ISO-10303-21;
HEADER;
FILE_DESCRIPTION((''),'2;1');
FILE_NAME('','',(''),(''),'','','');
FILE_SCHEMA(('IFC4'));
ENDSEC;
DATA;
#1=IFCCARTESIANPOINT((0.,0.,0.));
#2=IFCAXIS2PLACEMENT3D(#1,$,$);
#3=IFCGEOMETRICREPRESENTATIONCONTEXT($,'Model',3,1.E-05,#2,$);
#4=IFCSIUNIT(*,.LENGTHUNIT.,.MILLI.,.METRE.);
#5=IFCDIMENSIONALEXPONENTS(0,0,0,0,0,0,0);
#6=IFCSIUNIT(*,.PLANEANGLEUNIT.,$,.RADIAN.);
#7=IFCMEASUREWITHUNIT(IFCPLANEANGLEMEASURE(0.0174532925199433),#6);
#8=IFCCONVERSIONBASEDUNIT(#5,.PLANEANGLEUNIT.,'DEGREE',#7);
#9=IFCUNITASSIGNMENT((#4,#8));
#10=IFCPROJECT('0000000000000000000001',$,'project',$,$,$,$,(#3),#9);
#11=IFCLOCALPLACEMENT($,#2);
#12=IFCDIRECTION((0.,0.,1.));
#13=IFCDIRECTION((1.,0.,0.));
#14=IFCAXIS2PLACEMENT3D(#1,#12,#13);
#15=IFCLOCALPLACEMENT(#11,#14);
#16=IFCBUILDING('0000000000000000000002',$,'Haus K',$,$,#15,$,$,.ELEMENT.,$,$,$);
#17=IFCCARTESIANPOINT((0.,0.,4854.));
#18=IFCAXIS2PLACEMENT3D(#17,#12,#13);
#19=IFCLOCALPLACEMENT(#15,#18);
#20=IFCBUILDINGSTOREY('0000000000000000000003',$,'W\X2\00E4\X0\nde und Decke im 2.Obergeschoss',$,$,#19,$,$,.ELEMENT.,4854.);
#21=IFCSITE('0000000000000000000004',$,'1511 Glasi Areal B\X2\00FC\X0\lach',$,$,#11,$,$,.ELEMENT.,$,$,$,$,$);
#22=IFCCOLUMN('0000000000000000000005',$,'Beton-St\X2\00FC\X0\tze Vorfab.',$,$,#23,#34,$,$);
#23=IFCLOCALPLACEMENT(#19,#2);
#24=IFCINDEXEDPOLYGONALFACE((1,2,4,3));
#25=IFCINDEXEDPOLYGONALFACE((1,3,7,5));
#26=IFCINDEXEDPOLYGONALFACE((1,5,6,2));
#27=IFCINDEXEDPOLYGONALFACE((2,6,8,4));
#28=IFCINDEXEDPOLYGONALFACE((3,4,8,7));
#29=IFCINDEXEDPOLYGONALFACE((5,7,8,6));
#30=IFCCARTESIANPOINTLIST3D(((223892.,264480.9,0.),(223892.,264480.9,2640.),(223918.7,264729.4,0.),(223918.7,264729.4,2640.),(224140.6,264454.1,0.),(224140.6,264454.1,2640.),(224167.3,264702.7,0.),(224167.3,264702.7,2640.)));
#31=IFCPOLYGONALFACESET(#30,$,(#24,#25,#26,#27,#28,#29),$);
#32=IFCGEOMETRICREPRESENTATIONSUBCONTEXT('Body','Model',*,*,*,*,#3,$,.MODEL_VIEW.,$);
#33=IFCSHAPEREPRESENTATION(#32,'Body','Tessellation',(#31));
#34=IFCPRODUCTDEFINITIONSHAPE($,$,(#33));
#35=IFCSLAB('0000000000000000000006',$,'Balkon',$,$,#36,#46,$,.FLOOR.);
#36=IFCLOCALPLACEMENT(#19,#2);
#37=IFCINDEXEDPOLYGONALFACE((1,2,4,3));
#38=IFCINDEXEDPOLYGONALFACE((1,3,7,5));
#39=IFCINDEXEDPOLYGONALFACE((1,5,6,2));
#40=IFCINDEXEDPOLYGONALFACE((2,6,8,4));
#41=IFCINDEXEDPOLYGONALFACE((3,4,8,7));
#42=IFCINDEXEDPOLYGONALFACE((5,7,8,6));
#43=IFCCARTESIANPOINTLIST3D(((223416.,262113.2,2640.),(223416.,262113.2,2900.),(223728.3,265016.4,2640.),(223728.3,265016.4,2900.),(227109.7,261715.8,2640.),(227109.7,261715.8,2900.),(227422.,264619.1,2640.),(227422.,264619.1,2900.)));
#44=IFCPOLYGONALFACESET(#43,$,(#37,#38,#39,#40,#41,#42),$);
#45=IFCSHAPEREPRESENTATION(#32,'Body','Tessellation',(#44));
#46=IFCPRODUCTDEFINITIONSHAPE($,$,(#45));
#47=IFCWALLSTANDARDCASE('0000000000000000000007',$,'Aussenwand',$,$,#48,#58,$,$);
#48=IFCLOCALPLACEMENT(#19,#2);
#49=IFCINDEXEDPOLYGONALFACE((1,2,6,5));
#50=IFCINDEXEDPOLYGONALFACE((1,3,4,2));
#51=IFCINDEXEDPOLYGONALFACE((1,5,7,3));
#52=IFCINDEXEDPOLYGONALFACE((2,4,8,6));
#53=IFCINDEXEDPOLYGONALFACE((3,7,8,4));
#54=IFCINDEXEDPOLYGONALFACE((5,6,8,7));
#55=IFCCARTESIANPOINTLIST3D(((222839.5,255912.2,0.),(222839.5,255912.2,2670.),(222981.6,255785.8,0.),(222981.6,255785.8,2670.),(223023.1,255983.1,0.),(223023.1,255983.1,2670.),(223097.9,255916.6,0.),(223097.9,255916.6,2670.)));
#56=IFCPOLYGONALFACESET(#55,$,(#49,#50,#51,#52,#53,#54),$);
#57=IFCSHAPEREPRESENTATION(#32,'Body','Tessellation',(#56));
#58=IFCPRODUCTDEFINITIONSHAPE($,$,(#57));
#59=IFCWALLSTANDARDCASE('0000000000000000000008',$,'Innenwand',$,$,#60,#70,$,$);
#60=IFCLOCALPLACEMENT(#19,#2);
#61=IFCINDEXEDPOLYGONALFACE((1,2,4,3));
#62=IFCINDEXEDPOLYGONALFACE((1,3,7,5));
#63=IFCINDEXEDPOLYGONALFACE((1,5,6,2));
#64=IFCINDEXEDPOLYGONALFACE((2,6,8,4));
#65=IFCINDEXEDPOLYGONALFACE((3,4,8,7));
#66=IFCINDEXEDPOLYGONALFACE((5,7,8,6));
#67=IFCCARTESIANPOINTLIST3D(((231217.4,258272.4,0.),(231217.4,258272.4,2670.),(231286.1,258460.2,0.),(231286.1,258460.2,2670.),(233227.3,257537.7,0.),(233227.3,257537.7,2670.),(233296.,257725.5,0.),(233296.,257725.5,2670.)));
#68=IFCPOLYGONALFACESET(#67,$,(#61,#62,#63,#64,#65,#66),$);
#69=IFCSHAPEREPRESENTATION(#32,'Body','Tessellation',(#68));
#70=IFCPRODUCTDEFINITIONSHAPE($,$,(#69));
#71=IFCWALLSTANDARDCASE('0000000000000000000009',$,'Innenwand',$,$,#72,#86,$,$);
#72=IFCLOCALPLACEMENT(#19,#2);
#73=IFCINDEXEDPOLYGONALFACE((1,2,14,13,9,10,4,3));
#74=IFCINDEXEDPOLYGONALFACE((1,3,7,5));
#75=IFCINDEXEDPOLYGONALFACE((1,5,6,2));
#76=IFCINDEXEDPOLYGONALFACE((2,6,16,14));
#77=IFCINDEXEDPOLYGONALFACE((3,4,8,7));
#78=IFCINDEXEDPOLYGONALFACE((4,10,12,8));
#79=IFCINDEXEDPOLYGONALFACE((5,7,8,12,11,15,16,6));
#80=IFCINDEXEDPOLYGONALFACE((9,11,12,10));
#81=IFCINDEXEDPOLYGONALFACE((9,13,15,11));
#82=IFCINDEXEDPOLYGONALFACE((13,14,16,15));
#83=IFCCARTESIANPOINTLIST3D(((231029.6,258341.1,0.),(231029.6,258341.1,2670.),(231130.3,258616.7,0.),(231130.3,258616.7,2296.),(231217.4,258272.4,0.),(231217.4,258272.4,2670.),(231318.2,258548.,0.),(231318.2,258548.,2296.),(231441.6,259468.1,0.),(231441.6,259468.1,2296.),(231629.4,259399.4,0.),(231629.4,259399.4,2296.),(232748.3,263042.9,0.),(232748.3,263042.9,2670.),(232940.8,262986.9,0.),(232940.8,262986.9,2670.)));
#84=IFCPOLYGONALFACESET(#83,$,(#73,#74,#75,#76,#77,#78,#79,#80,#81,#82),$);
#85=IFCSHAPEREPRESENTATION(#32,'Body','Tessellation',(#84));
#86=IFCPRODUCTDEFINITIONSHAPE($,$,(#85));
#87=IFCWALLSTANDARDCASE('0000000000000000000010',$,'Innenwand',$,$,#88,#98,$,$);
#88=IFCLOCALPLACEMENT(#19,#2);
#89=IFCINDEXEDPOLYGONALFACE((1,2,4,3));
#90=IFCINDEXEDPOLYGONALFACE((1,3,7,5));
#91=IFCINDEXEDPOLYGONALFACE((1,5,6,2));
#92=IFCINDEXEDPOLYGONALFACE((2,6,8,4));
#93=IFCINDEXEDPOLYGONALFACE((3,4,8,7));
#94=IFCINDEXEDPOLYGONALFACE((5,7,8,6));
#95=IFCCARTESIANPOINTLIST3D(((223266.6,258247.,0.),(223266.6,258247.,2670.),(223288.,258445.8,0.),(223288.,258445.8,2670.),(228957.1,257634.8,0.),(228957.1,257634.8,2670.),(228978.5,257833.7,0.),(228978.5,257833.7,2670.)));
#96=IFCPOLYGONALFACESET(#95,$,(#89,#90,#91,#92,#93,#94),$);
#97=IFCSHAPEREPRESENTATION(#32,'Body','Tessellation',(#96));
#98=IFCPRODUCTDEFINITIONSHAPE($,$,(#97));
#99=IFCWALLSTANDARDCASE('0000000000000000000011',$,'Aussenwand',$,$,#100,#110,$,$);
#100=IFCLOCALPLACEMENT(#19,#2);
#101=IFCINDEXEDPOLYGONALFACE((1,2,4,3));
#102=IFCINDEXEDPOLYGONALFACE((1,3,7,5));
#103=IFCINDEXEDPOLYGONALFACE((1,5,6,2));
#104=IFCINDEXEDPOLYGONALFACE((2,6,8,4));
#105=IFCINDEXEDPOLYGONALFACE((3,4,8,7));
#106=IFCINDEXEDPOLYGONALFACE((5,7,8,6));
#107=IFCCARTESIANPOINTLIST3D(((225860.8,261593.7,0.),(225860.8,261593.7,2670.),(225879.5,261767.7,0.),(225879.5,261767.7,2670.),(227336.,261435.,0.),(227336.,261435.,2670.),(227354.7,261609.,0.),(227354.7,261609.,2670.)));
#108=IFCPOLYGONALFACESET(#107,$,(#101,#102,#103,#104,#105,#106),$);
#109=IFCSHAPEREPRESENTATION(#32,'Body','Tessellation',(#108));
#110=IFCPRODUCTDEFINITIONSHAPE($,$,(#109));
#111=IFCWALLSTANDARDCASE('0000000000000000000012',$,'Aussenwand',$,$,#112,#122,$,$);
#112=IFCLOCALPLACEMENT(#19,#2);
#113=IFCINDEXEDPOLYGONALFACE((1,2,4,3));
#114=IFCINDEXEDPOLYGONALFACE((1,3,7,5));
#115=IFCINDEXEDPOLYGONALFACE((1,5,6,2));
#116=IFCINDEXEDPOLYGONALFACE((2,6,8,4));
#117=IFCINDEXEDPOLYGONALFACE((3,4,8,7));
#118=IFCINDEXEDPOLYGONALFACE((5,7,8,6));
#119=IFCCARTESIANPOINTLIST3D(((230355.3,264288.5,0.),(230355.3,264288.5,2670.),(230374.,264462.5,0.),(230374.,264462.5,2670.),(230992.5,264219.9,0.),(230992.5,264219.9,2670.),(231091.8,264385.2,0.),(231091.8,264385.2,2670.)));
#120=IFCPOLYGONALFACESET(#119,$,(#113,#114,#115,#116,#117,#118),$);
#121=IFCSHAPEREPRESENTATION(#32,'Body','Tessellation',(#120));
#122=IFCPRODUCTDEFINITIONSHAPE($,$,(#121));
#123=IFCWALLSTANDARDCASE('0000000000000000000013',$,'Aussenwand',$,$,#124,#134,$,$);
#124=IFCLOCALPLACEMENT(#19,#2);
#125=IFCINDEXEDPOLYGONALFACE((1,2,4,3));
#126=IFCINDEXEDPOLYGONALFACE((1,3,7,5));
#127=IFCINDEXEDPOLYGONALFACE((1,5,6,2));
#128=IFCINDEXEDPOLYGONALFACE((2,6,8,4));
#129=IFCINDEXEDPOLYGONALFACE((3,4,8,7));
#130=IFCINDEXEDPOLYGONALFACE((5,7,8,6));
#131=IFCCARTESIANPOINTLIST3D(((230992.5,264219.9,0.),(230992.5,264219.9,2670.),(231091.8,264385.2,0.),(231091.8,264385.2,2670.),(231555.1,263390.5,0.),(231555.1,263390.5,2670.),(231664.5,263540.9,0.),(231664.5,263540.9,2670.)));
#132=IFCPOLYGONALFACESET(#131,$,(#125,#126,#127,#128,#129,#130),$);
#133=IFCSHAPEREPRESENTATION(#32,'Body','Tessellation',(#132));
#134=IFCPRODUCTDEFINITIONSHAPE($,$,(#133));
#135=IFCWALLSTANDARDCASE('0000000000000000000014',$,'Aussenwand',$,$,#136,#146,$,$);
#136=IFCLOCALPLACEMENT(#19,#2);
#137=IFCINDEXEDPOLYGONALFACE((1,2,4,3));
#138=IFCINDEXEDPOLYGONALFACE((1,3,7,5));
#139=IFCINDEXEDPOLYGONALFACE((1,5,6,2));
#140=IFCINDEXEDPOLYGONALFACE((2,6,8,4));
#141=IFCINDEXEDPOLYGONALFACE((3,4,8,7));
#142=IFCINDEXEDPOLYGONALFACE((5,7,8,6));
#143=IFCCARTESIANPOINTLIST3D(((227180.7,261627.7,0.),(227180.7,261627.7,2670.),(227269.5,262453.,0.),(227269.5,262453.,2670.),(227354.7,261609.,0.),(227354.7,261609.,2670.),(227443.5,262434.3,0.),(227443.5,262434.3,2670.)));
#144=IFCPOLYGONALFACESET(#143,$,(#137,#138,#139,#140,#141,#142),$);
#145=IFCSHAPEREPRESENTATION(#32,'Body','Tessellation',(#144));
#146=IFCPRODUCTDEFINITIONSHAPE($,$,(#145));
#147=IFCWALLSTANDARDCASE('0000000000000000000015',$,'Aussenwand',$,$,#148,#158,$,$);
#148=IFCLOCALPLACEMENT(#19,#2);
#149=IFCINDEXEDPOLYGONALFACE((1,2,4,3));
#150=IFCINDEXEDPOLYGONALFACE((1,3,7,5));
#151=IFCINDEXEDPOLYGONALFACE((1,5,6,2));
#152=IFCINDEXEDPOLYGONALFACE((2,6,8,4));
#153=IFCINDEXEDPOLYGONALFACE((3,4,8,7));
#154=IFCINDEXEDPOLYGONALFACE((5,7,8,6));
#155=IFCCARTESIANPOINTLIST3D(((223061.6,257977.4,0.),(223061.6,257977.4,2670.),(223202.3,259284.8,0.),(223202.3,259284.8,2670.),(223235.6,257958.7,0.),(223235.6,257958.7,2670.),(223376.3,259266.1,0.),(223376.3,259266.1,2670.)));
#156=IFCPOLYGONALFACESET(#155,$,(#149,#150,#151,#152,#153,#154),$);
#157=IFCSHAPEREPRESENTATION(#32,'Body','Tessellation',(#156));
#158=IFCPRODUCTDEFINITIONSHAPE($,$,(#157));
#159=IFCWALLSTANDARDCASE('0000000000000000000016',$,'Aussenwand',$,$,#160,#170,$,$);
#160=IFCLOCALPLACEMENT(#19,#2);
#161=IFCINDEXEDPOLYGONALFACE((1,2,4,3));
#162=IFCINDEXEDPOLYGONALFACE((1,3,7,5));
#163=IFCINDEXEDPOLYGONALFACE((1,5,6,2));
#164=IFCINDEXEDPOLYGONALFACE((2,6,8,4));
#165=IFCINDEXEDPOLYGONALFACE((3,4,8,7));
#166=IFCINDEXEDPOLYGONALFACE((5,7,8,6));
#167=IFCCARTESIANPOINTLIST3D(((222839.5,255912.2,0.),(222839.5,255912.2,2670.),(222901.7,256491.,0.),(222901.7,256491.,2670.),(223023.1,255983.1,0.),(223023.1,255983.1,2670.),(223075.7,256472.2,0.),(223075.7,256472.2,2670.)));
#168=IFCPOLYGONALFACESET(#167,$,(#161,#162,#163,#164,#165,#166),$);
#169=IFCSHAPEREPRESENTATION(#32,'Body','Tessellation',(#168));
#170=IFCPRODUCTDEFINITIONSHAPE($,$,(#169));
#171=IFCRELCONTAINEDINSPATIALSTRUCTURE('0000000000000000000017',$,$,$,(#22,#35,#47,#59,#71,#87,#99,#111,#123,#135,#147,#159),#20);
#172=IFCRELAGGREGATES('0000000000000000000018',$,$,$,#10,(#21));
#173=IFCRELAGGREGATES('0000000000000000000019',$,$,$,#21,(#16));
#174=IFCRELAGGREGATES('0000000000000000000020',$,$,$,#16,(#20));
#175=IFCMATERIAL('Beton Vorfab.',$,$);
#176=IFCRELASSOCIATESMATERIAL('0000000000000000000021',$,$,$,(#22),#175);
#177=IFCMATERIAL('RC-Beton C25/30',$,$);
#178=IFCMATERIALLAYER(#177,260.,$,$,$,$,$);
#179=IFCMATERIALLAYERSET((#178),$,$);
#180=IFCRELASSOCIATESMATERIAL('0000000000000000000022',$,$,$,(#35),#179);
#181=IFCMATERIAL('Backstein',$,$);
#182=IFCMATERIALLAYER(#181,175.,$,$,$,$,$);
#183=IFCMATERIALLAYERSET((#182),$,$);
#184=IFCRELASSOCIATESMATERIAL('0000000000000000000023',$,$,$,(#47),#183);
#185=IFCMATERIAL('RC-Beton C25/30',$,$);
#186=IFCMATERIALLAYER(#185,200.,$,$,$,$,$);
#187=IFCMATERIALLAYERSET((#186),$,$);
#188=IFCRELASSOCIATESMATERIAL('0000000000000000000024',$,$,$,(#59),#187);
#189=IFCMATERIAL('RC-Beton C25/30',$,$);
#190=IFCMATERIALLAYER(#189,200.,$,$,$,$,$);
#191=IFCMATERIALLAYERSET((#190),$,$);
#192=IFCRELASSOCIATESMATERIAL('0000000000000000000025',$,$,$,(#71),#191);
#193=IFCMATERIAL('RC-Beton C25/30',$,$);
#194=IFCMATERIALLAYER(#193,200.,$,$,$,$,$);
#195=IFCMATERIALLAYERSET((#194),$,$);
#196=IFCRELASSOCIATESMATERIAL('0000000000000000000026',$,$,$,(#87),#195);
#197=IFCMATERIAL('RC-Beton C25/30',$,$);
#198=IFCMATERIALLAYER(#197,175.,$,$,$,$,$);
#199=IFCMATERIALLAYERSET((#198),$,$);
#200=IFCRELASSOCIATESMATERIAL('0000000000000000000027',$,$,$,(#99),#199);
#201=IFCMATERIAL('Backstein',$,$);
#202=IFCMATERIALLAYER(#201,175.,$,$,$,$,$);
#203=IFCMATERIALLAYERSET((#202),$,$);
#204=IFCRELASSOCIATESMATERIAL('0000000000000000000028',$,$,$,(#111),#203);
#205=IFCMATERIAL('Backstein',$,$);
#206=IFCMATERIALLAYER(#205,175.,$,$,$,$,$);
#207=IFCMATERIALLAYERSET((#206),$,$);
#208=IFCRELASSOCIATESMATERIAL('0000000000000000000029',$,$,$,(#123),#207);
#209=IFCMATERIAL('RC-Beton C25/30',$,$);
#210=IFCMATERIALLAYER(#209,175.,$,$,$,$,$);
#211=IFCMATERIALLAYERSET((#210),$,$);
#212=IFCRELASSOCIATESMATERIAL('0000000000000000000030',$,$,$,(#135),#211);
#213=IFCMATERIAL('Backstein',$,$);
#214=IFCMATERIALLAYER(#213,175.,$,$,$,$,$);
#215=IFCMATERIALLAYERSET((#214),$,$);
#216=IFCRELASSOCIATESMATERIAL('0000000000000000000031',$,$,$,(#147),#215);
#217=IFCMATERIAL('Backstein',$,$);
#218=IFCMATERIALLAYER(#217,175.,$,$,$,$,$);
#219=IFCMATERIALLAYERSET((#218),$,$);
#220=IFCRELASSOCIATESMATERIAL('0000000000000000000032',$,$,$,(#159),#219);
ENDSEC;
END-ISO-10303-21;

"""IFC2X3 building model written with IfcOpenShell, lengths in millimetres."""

from ifc_helpers import new_model, entity, si_unit, converted_unit, frame, frame_2d, origin, origin_with_axes, place, context, subcontext, project, spatial, polyline, rectangle, outline, extrude, material, layer, layer_set, layer_usage, element, save


model = new_model("IFC2X3")

# Units and contexts
model_context = context("Model", 3, precision=1e-05, world=origin())
body_context = subcontext(model_context, "Body", "Model", "MODEL_VIEW")
ifc_project = project(units=[si_unit("LENGTHUNIT", "METRE", prefix="MILLI"), converted_unit("PLANEANGLEUNIT", "DEGREE", entity("IfcPlaneAngleMeasure", 0.0174532925199433), si_unit("PLANEANGLEUNIT", "RADIAN"), dimensions=[0, 0, 0, 0, 0, 0, 0])], contexts=[model_context])

# Site, building, storey
site_placement = place(None, origin())
site = spatial("IfcSite", under=ifc_project, at=site_placement, Name="1511 Glasi Areal Bülach", CompositionType="ELEMENT")
building_placement = place(site_placement, origin_with_axes())
building = spatial("IfcBuilding", under=site, at=building_placement, Name="Haus K", CompositionType="ELEMENT")
storey_placement = place(building_placement, frame((0.0, 0.0, 4854.0), z_axis=(0.0, 0.0, 1.0), x_axis=(1.0, 0.0, 0.0)))
storey = spatial("IfcBuildingStorey", under=building, at=storey_placement, Name="Wände und Decke im 2.Obergeschoss", CompositionType="ELEMENT", Elevation=4854.0)

# Column
ifc_material_1 = material(Name="Beton Vorfab.")
column_placement = place(storey_placement, frame((223892.0, 264480.9, 0.0), z_axis=(0.0, 0.0, 1.0), x_axis=(1.0, 0.0, 0.0)))
element("IfcColumn", 1, at=column_placement, inside=storey, material=ifc_material_1, Name="Beton-Stütze Vorfab.", context=body_context, shape_type="SweptSolid", body=[
    extrude(rectangle(XDim=250.0, YDim=250.0, at=frame_2d((137.7, 110.9), x_axis=(0.994264, -0.106958))), origin_with_axes(), (0.0, 0.0, 1.0), 2640.0),
])

# Slab
ifc_material_2 = material(Name="RC-Beton C25/30")
ifc_layer_1 = layer(ifc_material_2, 260.0)
ifc_layer_set_1 = layer_set([ifc_layer_1])
ifc_layer_usage_1 = layer_usage(ifc_layer_set_1, "AXIS3", "POSITIVE", 0.0)
slab_placement = place(storey_placement, frame((223728.3, 265016.4, 2640.0), z_axis=(0.0, 0.0, 1.0), x_axis=(1.0, 0.0, 0.0)))
element("IfcSlab", 2, at=slab_placement, inside=storey, material=ifc_layer_usage_1, Name="Balkon", PredefinedType="FLOOR", context=body_context, shape_type="SweptSolid", body=[
    extrude(rectangle(XDim=2920.0, YDim=3715.0, at=frame_2d((1690.7, -1650.3), x_axis=(-0.106958, -0.994264))), origin_with_axes(), (0.0, 0.0, 1.0), 260.0),
])

# Walls
ifc_material_3 = material(Name="Backstein")
ifc_layer_2 = layer(ifc_material_3, 175.0)
ifc_layer_set_2 = layer_set([ifc_layer_2])
ifc_layer_usage_2 = layer_usage(ifc_layer_set_2, "AXIS2", "POSITIVE", 0.0)
wall_1_placement = place(storey_placement, frame((222839.5, 255912.2, 0.0), z_axis=(0.0, 0.0, 1.0), x_axis=(0.747334, -0.664448, 0.0)))
element("IfcWallStandardCase", 3, at=wall_1_placement, inside=storey, material=ifc_layer_usage_2, Name="Aussenwand", context=body_context, shape_type="SweptSolid", body=[
    extrude(outline(polyline([(0.0, 0.0), (190.2, 0.0), (190.2, 175.0), (90.1, 175.0), (0.0, 0.0)])), origin_with_axes(), (0.0, 0.0, 1.0), 2670.0),
])
ifc_material_4 = material(Name="RC-Beton C25/30")
ifc_layer_3 = layer(ifc_material_4, 200.0)
ifc_layer_set_3 = layer_set([ifc_layer_3])
ifc_layer_usage_3 = layer_usage(ifc_layer_set_3, "AXIS2", "POSITIVE", 0.0)
wall_2_placement = place(storey_placement, frame((233296.0, 257725.5, 0.0), z_axis=(0.0, 0.0, 1.0), x_axis=(-0.939214, 0.343332, 0.0)))
element("IfcWallStandardCase", 4, at=wall_2_placement, inside=storey, material=ifc_layer_usage_3, Name="Innenwand", context=body_context, shape_type="SweptSolid", body=[
    extrude(rectangle(XDim=2140.0, YDim=200.0, at=frame_2d((1070.0, 100.0), x_axis=(1.0, 0.0))), origin_with_axes(), (0.0, 0.0, 1.0), 2670.0),
])

# Wall, opening
ifc_material_5 = material(Name="RC-Beton C25/30")
ifc_layer_4 = layer(ifc_material_5, 200.0)
ifc_layer_set_4 = layer_set([ifc_layer_4])
ifc_layer_usage_4 = layer_usage(ifc_layer_set_4, "AXIS2", "POSITIVE", 0.0)
wall_3_placement = place(storey_placement, frame((232748.3, 263042.9, 0.0), z_axis=(0.0, 0.0, 1.0), x_axis=(-0.343332, -0.939214, 0.0)))
wall_3 = element("IfcWallStandardCase", 5, at=wall_3_placement, inside=storey, material=ifc_layer_usage_4, Name="Innenwand", context=body_context, shape_type="SweptSolid", body=[
    extrude(outline(polyline([(0.0, 0.0), (5006.2, 0.0), (5006.2, 200.0), (-13.4, 200.0), (0.0, 0.0)])), origin_with_axes(), (0.0, 0.0, 1.0), 2670.0),
])
opening_1_placement = place(wall_3_placement, frame((3806.2, 0.0, 0.0), z_axis=(0.0, 1.0, 0.0), x_axis=(0.0, 0.0, 1.0)))
element("IfcOpeningElement", 6, at=opening_1_placement, cuts=wall_3, ObjectType="Opening", context=body_context, shape_type="SweptSolid", body=[
    extrude(rectangle(XDim=2296.0, YDim=906.5, at=frame_2d((1148.0, 453.3), x_axis=(1.0, 0.0))), origin_with_axes(), (0.0, 0.0, 1.0), 200.0),
])

# Walls
ifc_material_6 = material(Name="RC-Beton C25/30")
ifc_layer_5 = layer(ifc_material_6, 200.0)
ifc_layer_set_5 = layer_set([ifc_layer_5])
ifc_layer_usage_5 = layer_usage(ifc_layer_set_5, "AXIS2", "POSITIVE", 0.0)
wall_4_placement = place(storey_placement, frame((223266.6, 258247.0, 0.0), z_axis=(0.0, 0.0, 1.0), x_axis=(0.994264, -0.106958, 0.0)))
element("IfcWallStandardCase", 7, at=wall_4_placement, inside=storey, material=ifc_layer_usage_5, Name="Innenwand", context=body_context, shape_type="SweptSolid", body=[
    extrude(rectangle(XDim=5723.3, YDim=200.0, at=frame_2d((2861.6, 100.0), x_axis=(1.0, 0.0))), origin_with_axes(), (0.0, 0.0, 1.0), 2670.0),
])
ifc_material_7 = material(Name="RC-Beton C25/30")
ifc_layer_6 = layer(ifc_material_7, 175.0)
ifc_layer_set_6 = layer_set([ifc_layer_6])
ifc_layer_usage_6 = layer_usage(ifc_layer_set_6, "AXIS2", "POSITIVE", 0.0)
wall_5_placement = place(storey_placement, frame((227354.7, 261609.0, 0.0), z_axis=(0.0, 0.0, 1.0), x_axis=(-0.994264, 0.106958, 0.0)))
element("IfcWallStandardCase", 8, at=wall_5_placement, inside=storey, material=ifc_layer_usage_6, Name="Aussenwand", context=body_context, shape_type="SweptSolid", body=[
    extrude(rectangle(XDim=1483.7, YDim=175.0, at=frame_2d((741.9, 87.5), x_axis=(1.0, 0.0))), origin_with_axes(), (0.0, 0.0, 1.0), 2670.0),
])
ifc_material_8 = material(Name="Backstein")
ifc_layer_7 = layer(ifc_material_8, 175.0)
ifc_layer_set_7 = layer_set([ifc_layer_7])
ifc_layer_usage_7 = layer_usage(ifc_layer_set_7, "AXIS2", "POSITIVE", 0.0)
wall_6_placement = place(storey_placement, frame((231091.8, 264385.2, 0.0), z_axis=(0.0, 0.0, 1.0), x_axis=(-0.994264, 0.106958, 0.0)))
element("IfcWallStandardCase", 9, at=wall_6_placement, inside=storey, material=ifc_layer_usage_7, Name="Aussenwand", context=body_context, shape_type="SweptSolid", body=[
    extrude(outline(polyline([(0.0, 0.0), (721.9, 0.0), (721.9, 175.0), (81.1, 175.0), (0.0, 0.0)])), origin_with_axes(), (0.0, 0.0, 1.0), 2670.0),
])
ifc_material_9 = material(Name="Backstein")
ifc_layer_8 = layer(ifc_material_9, 175.0)
ifc_layer_set_8 = layer_set([ifc_layer_8])
ifc_layer_usage_8 = layer_usage(ifc_layer_set_8, "AXIS2", "POSITIVE", 0.0)
wall_7_placement = place(storey_placement, frame((231664.5, 263540.9, 0.0), z_axis=(0.0, 0.0, 1.0), x_axis=(-0.561361, 0.827571, 0.0)))
element("IfcWallStandardCase", 10, at=wall_7_placement, inside=storey, material=ifc_layer_usage_8, Name="Aussenwand", context=body_context, shape_type="SweptSolid", body=[
    extrude(outline(polyline([(0.0, 0.0), (1020.3, 0.0), (939.2, 175.0), (-63.0, 175.0), (0.0, 0.0)])), origin_with_axes(), (0.0, 0.0, 1.0), 2670.0),
])
ifc_material_10 = material(Name="RC-Beton C25/30")
ifc_layer_9 = layer(ifc_material_10, 175.0)
ifc_layer_set_9 = layer_set([ifc_layer_9])
ifc_layer_usage_9 = layer_usage(ifc_layer_set_9, "AXIS2", "POSITIVE", 0.0)
wall_8_placement = place(storey_placement, frame((227269.5, 262453.0, 0.0), z_axis=(0.0, 0.0, 1.0), x_axis=(-0.106958, -0.994264, 0.0)))
element("IfcWallStandardCase", 11, at=wall_8_placement, inside=storey, material=ifc_layer_usage_9, Name="Aussenwand", context=body_context, shape_type="SweptSolid", body=[
    extrude(rectangle(XDim=830.0, YDim=175.0, at=frame_2d((415.0, 87.5), x_axis=(1.0, 0.0))), origin_with_axes(), (0.0, 0.0, 1.0), 2670.0),
])
ifc_material_11 = material(Name="Backstein")
ifc_layer_10 = layer(ifc_material_11, 175.0)
ifc_layer_set_10 = layer_set([ifc_layer_10])
ifc_layer_usage_10 = layer_usage(ifc_layer_set_10, "AXIS2", "POSITIVE", 0.0)
wall_9_placement = place(storey_placement, frame((223202.3, 259284.8, 0.0), z_axis=(0.0, 0.0, 1.0), x_axis=(-0.106958, -0.994264, 0.0)))
element("IfcWallStandardCase", 12, at=wall_9_placement, inside=storey, material=ifc_layer_usage_10, Name="Aussenwand", context=body_context, shape_type="SweptSolid", body=[
    extrude(rectangle(XDim=1315.0, YDim=175.0, at=frame_2d((657.5, 87.5), x_axis=(1.0, 0.0))), origin_with_axes(), (0.0, 0.0, 1.0), 2670.0),
])
ifc_material_12 = material(Name="Backstein")
ifc_layer_11 = layer(ifc_material_12, 175.0)
ifc_layer_set_11 = layer_set([ifc_layer_11])
ifc_layer_usage_11 = layer_usage(ifc_layer_set_11, "AXIS2", "POSITIVE", 0.0)
wall_10_placement = place(storey_placement, frame((222901.7, 256491.0, 0.0), z_axis=(0.0, 0.0, 1.0), x_axis=(-0.106958, -0.994264, 0.0)))
element("IfcWallStandardCase", 13, at=wall_10_placement, inside=storey, material=ifc_layer_usage_11, Name="Aussenwand", context=body_context, shape_type="SweptSolid", body=[
    extrude(outline(polyline([(0.0, 0.0), (582.1, 0.0), (492.0, 175.0), (0.0, 175.0), (0.0, 0.0)])), origin_with_axes(), (0.0, 0.0, 1.0), 2670.0),
])

save(model, "model.ifc")
